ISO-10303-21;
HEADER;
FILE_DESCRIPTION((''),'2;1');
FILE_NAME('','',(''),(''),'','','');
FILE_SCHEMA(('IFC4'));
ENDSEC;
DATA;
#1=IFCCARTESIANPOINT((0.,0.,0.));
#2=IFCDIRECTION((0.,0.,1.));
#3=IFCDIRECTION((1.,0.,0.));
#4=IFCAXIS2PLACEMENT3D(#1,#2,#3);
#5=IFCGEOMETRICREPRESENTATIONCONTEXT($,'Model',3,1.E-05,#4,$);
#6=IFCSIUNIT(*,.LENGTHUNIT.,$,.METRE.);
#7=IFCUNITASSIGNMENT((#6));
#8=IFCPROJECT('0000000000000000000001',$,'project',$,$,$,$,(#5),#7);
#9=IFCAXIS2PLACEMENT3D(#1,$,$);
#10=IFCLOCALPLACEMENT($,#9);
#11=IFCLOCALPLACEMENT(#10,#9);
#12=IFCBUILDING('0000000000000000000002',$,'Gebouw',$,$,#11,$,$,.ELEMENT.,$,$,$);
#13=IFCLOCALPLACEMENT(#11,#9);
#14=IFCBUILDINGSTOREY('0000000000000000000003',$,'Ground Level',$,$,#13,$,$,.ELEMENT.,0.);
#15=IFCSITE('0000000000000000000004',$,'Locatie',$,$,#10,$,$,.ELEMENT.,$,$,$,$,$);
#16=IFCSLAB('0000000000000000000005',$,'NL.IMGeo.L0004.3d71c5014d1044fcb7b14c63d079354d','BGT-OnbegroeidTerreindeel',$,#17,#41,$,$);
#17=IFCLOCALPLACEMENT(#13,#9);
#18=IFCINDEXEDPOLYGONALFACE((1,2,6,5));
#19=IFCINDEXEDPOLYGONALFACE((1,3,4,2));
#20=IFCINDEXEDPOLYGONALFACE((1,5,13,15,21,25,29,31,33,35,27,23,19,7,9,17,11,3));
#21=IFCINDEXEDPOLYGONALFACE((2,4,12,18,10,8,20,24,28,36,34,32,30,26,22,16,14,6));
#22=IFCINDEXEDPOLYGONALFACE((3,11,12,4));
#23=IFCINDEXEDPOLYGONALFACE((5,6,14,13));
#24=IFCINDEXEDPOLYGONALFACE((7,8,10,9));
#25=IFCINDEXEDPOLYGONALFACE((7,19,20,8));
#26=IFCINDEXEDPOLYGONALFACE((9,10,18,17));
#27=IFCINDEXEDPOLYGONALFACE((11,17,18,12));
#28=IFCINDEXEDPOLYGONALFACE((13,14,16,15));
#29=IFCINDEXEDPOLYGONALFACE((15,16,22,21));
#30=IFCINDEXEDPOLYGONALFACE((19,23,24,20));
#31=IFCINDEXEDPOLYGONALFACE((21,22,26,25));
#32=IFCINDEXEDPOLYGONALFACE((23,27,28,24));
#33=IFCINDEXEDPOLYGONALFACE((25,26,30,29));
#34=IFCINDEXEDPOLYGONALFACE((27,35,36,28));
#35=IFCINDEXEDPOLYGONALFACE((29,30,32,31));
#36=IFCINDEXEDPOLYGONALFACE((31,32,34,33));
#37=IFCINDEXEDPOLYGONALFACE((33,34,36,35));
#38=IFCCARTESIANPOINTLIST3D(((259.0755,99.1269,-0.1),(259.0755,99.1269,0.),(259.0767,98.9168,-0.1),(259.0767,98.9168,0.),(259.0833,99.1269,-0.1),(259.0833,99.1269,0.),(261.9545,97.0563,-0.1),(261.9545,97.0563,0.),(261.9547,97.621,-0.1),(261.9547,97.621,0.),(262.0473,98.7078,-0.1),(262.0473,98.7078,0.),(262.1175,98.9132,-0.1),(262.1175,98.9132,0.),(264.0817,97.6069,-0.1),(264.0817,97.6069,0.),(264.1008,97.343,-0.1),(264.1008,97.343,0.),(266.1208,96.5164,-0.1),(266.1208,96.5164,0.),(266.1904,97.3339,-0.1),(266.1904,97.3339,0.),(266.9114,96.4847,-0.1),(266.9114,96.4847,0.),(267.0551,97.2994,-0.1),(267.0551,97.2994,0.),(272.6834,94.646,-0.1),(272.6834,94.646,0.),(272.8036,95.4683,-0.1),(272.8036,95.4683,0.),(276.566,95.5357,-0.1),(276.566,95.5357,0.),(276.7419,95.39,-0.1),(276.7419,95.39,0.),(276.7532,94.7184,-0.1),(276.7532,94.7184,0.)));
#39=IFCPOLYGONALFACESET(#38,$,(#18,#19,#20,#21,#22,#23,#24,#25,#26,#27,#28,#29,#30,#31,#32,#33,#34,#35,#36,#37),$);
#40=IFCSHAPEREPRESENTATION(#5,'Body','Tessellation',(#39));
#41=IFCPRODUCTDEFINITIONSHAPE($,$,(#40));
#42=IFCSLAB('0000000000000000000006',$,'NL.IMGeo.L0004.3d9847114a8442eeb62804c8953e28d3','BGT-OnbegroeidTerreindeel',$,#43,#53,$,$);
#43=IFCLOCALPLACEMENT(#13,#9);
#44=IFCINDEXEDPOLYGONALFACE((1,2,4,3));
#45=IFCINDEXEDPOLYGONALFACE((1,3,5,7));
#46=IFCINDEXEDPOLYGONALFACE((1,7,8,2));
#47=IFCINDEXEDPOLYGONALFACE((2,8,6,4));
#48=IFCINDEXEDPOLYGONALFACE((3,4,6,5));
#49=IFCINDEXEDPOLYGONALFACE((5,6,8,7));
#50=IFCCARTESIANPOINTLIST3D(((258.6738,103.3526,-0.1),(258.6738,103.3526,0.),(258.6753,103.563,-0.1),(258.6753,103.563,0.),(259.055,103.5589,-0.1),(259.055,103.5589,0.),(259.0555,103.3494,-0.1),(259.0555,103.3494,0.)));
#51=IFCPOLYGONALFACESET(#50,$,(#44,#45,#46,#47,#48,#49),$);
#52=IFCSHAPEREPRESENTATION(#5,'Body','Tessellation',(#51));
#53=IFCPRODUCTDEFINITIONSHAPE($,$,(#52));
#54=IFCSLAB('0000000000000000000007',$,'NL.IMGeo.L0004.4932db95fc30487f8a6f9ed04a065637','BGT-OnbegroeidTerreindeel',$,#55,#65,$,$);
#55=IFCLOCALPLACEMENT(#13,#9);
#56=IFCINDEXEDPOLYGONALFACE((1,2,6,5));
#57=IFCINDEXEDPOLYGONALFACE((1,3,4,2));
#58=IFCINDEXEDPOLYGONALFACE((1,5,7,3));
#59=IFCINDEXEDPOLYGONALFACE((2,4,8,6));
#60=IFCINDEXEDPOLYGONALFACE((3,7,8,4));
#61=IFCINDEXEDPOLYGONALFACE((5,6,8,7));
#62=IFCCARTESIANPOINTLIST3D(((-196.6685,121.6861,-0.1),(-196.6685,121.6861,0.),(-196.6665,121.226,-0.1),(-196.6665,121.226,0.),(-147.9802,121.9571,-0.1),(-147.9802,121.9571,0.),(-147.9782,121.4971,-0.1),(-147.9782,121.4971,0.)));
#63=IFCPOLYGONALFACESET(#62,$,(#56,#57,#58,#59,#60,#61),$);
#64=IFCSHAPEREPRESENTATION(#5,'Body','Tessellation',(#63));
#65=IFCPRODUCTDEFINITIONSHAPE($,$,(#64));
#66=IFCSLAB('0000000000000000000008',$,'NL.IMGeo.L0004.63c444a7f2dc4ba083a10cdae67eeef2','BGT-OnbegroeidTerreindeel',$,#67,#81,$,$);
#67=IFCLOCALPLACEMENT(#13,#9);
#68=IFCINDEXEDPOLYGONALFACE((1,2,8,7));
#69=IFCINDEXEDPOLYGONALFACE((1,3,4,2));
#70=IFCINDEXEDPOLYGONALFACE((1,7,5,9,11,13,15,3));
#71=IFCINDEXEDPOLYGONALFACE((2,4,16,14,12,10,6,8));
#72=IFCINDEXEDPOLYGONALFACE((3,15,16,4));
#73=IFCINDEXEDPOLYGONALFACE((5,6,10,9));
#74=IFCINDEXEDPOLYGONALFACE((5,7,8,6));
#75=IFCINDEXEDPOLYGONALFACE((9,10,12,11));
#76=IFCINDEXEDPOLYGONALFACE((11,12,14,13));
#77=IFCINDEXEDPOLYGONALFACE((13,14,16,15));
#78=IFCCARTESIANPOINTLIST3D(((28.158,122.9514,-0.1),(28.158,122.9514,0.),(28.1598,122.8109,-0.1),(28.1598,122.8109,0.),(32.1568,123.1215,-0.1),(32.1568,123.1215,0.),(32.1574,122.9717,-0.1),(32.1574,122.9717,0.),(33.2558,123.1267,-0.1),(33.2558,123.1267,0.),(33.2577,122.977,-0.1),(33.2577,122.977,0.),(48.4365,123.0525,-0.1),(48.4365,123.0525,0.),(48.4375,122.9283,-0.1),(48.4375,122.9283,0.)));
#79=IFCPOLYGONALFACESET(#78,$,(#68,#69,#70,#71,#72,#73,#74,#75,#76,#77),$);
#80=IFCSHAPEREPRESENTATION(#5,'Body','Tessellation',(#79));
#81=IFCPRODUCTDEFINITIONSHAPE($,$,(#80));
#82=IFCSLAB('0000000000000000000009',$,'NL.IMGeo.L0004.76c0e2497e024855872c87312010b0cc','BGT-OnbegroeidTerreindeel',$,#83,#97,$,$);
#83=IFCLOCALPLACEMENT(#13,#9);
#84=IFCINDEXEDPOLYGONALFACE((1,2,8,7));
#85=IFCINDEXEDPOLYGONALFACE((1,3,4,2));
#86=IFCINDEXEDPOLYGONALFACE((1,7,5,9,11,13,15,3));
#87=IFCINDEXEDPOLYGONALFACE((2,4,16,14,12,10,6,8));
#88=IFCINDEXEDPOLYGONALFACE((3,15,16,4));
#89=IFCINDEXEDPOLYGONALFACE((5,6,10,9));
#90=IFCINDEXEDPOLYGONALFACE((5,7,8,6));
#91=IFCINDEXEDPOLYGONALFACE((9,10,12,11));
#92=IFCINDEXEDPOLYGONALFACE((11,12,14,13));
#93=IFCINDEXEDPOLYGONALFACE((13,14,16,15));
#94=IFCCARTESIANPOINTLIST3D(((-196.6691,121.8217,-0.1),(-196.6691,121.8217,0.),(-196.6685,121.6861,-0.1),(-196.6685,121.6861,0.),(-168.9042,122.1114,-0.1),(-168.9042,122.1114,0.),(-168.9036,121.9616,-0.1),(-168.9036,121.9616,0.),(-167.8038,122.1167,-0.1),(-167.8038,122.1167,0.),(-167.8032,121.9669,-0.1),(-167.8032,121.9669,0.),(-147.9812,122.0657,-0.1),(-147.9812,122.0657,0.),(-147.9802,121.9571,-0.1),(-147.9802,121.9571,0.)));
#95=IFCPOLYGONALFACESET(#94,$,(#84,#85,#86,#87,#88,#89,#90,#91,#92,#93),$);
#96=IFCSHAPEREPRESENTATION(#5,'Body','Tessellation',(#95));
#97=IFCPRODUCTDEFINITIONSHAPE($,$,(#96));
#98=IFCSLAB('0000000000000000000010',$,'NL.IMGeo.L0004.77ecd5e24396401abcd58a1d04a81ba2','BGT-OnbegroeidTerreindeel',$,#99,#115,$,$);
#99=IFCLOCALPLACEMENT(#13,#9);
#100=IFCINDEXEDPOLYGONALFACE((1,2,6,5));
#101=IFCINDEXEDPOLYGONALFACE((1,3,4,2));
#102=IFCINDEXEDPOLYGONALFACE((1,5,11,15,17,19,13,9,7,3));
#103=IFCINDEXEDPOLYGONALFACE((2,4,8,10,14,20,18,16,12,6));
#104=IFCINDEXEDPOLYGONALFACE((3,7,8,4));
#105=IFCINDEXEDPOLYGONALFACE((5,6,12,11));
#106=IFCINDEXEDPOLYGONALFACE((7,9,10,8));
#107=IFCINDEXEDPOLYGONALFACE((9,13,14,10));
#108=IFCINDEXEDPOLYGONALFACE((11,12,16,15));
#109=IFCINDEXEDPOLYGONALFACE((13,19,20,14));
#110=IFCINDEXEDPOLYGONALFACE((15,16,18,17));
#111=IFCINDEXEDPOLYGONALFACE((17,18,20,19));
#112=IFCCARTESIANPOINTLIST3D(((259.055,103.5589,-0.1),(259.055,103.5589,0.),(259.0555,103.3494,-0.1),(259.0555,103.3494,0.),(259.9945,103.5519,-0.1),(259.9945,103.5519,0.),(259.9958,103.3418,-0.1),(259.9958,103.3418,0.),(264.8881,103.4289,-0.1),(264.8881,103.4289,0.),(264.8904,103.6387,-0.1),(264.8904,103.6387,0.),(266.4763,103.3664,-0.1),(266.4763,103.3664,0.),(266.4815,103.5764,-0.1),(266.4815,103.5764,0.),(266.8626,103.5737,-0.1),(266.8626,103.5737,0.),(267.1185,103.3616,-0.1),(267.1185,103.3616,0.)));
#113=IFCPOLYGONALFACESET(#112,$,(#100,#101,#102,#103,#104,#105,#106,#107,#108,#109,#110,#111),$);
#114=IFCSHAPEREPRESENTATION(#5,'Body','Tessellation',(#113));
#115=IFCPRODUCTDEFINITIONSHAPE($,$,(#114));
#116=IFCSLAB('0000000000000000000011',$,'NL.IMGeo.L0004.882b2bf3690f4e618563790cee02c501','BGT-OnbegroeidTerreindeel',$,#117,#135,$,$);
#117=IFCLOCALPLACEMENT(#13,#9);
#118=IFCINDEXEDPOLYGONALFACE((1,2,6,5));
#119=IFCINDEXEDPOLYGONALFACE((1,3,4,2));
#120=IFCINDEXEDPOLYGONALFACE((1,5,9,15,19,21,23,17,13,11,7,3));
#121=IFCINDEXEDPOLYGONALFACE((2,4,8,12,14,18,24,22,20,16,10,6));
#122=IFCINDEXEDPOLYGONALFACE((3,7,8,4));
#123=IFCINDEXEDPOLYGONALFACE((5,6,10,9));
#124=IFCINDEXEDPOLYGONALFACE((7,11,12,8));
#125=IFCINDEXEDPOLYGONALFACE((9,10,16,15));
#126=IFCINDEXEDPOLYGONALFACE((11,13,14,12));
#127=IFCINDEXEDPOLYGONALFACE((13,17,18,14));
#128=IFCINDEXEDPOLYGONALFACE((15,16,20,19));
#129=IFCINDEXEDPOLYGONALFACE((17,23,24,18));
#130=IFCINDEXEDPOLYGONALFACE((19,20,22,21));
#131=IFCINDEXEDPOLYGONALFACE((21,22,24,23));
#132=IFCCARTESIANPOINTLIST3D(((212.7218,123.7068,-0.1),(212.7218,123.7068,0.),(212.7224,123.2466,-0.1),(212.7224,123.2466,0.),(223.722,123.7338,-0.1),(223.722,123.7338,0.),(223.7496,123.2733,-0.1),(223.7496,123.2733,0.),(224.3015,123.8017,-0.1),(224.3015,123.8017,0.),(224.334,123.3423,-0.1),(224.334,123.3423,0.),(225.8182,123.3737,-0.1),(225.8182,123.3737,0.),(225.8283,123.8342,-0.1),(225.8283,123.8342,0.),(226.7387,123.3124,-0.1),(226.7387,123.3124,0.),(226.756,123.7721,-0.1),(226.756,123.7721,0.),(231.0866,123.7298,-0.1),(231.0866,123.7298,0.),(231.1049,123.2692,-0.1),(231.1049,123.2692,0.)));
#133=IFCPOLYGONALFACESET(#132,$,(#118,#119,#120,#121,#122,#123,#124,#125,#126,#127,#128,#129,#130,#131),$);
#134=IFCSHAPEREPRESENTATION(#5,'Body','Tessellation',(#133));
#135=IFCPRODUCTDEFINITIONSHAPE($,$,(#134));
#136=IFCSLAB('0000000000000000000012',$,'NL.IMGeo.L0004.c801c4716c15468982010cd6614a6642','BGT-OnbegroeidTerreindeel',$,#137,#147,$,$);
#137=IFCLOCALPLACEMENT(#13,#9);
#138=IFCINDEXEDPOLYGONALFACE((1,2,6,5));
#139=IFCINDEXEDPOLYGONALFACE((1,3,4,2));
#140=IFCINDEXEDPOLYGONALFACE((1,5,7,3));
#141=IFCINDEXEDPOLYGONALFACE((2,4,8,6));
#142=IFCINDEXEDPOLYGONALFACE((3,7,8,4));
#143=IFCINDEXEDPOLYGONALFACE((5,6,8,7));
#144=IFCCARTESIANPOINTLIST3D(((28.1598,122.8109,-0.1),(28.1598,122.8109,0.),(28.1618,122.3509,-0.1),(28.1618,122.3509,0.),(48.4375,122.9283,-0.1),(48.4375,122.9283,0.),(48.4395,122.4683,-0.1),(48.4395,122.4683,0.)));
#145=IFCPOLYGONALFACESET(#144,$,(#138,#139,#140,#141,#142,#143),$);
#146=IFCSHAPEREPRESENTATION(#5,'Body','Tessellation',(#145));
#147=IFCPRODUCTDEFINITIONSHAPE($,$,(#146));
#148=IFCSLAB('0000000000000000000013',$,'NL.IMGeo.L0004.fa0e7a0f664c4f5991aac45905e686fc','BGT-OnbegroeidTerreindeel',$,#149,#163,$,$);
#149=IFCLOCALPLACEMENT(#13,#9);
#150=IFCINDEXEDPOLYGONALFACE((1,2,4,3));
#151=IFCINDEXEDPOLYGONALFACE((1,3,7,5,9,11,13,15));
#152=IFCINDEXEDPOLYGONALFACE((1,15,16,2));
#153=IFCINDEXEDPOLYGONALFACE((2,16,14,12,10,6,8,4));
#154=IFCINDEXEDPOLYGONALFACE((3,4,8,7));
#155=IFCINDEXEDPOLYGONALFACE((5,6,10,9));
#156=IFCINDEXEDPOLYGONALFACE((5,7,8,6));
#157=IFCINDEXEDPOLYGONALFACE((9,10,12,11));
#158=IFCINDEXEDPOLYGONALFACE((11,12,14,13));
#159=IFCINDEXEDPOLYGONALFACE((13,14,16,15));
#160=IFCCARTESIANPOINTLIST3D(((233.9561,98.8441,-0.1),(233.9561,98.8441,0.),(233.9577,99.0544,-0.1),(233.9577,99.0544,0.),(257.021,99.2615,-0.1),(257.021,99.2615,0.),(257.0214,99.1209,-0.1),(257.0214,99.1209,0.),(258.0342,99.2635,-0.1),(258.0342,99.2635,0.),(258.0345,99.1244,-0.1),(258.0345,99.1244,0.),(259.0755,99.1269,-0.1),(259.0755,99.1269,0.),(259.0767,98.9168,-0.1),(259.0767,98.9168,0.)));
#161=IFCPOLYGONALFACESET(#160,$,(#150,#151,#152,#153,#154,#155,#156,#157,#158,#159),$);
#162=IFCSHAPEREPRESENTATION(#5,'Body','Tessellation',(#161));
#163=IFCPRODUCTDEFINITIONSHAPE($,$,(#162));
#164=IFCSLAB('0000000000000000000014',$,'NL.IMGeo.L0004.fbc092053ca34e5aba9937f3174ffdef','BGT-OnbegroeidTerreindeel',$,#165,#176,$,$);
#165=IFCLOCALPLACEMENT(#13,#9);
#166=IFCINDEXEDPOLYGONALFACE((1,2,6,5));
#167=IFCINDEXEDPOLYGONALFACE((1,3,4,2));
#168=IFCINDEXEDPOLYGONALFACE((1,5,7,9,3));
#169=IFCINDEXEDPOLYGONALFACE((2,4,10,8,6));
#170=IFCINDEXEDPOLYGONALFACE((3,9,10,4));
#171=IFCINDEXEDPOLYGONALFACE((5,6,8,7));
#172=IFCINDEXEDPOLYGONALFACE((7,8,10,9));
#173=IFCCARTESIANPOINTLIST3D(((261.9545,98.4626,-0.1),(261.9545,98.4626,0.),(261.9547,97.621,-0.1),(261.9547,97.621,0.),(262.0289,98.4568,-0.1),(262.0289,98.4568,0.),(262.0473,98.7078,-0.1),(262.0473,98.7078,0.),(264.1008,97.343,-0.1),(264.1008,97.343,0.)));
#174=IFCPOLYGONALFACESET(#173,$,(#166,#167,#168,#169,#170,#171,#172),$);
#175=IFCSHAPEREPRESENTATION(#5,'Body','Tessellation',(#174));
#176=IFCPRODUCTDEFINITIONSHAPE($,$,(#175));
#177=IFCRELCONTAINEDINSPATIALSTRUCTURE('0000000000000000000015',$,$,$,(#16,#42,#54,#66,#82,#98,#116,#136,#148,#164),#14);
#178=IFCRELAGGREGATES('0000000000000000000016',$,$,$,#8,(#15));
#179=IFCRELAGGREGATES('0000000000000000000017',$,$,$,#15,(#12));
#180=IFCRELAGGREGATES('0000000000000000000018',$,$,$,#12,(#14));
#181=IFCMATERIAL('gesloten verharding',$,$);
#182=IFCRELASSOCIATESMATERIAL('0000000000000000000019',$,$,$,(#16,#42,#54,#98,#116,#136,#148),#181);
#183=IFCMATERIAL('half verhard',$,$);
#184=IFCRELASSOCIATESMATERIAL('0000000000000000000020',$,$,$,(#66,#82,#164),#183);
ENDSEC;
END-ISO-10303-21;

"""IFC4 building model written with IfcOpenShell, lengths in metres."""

from ifc_helpers import new_model, si_unit, frame, origin, origin_with_axes, place, context, project, spatial, polyline, outline, extrude, material, element, save


model = new_model("IFC4")

# Units and contexts
model_context = context("Model", 3, precision=1e-05, world=origin_with_axes())
ifc_project = project(units=[si_unit("LENGTHUNIT", "METRE")], contexts=[model_context])

# Site, building, storey
site_placement = place(None, origin())
site = spatial("IfcSite", under=ifc_project, at=site_placement, Name="Locatie", CompositionType="ELEMENT")
building_placement = place(site_placement, origin())
building = spatial("IfcBuilding", under=site, at=building_placement, Name="Gebouw", CompositionType="ELEMENT")
storey_placement = place(building_placement, origin())
storey = spatial("IfcBuildingStorey", under=building, at=storey_placement, Name="Ground Level", CompositionType="ELEMENT", Elevation=0.0)

# Slabs
ifc_material_1 = material(Name="gesloten verharding")
ifc_material_2 = material(Name="half verhard")
slab_1_placement = place(storey_placement, origin())
element("IfcSlab", 1, at=slab_1_placement, inside=storey, material=ifc_material_1, Name="NL.IMGeo.L0004.3d71c5014d1044fcb7b14c63d079354d", Description="BGT-OnbegroeidTerreindeel", context=model_context, shape_type="SweptSolid", body=[
    extrude(outline(polyline([(276.7532, 94.7184), (272.6834, 94.646), (266.9114, 96.4847), (266.1208, 96.5164), (261.9545, 97.0563), (261.9547, 97.621), (264.1008, 97.343), (262.0473, 98.7078), (259.0767, 98.9168), (259.0755, 99.1269), (259.0833, 99.1269), (262.1175, 98.9132), (264.0817, 97.6069), (266.1904, 97.3339), (267.0551, 97.2994), (272.8036, 95.4683), (276.566, 95.5357), (276.7419, 95.39), (276.7532, 94.7184)])), frame((0.0, 0.0, -0.1), z_axis=(0.0, 0.0, 1.0), x_axis=(1.0, 0.0, 0.0)), (0.0, 0.0, 1.0), 0.1),
])
slab_2_placement = place(storey_placement, origin())
element("IfcSlab", 2, at=slab_2_placement, inside=storey, material=ifc_material_1, Name="NL.IMGeo.L0004.3d9847114a8442eeb62804c8953e28d3", Description="BGT-OnbegroeidTerreindeel", context=model_context, shape_type="SweptSolid", body=[
    extrude(outline(polyline([(258.6738, 103.3526), (258.6753, 103.563), (259.055, 103.5589), (259.0555, 103.3494), (258.6738, 103.3526)])), frame((0.0, 0.0, -0.1), z_axis=(0.0, 0.0, 1.0), x_axis=(1.0, 0.0, 0.0)), (0.0, 0.0, 1.0), 0.1),
])
slab_3_placement = place(storey_placement, origin())
element("IfcSlab", 3, at=slab_3_placement, inside=storey, material=ifc_material_1, Name="NL.IMGeo.L0004.4932db95fc30487f8a6f9ed04a065637", Description="BGT-OnbegroeidTerreindeel", context=model_context, shape_type="SweptSolid", body=[
    extrude(outline(polyline([(-196.6685, 121.6861), (-147.9802, 121.9571), (-147.9782, 121.4971), (-196.6665, 121.226), (-196.6685, 121.6861)])), frame((0.0, 0.0, -0.1), z_axis=(0.0, 0.0, 1.0), x_axis=(1.0, 0.0, 0.0)), (0.0, 0.0, 1.0), 0.1),
])
slab_4_placement = place(storey_placement, origin())
element("IfcSlab", 4, at=slab_4_placement, inside=storey, material=ifc_material_2, Name="NL.IMGeo.L0004.63c444a7f2dc4ba083a10cdae67eeef2", Description="BGT-OnbegroeidTerreindeel", context=model_context, shape_type="SweptSolid", body=[
    extrude(outline(polyline([(28.158, 122.9514), (32.1574, 122.9717), (32.1568, 123.1215), (33.2558, 123.1267), (33.2577, 122.977), (48.4365, 123.0525), (48.4375, 122.9283), (28.1598, 122.8109), (28.158, 122.9514)])), frame((0.0, 0.0, -0.1), z_axis=(0.0, 0.0, 1.0), x_axis=(1.0, 0.0, 0.0)), (0.0, 0.0, 1.0), 0.1),
])
slab_5_placement = place(storey_placement, origin())
element("IfcSlab", 5, at=slab_5_placement, inside=storey, material=ifc_material_2, Name="NL.IMGeo.L0004.76c0e2497e024855872c87312010b0cc", Description="BGT-OnbegroeidTerreindeel", context=model_context, shape_type="SweptSolid", body=[
    extrude(outline(polyline([(-196.6691, 121.8217), (-168.9036, 121.9616), (-168.9042, 122.1114), (-167.8038, 122.1167), (-167.8032, 121.9669), (-147.9812, 122.0657), (-147.9802, 121.9571), (-196.6685, 121.6861), (-196.6691, 121.8217)])), frame((0.0, 0.0, -0.1), z_axis=(0.0, 0.0, 1.0), x_axis=(1.0, 0.0, 0.0)), (0.0, 0.0, 1.0), 0.1),
])
slab_6_placement = place(storey_placement, origin())
element("IfcSlab", 6, at=slab_6_placement, inside=storey, material=ifc_material_1, Name="NL.IMGeo.L0004.77ecd5e24396401abcd58a1d04a81ba2", Description="BGT-OnbegroeidTerreindeel", context=model_context, shape_type="SweptSolid", body=[
    extrude(outline(polyline([(266.4763, 103.3664), (264.8881, 103.4289), (259.9958, 103.3418), (259.0555, 103.3494), (259.055, 103.5589), (259.9945, 103.5519), (264.8904, 103.6387), (266.4815, 103.5764), (266.8626, 103.5737), (267.1185, 103.3616), (266.4763, 103.3664)])), frame((0.0, 0.0, -0.1), z_axis=(0.0, 0.0, 1.0), x_axis=(1.0, 0.0, 0.0)), (0.0, 0.0, 1.0), 0.1),
])
slab_7_placement = place(storey_placement, origin())
element("IfcSlab", 7, at=slab_7_placement, inside=storey, material=ifc_material_1, Name="NL.IMGeo.L0004.882b2bf3690f4e618563790cee02c501", Description="BGT-OnbegroeidTerreindeel", context=model_context, shape_type="SweptSolid", body=[
    extrude(outline(polyline([(212.7218, 123.7068), (223.722, 123.7338), (224.3015, 123.8017), (225.8283, 123.8342), (226.756, 123.7721), (231.0866, 123.7298), (231.1049, 123.2692), (226.7387, 123.3124), (225.8182, 123.3737), (224.334, 123.3423), (223.7496, 123.2733), (212.7224, 123.2466), (212.7218, 123.7068)])), frame((0.0, 0.0, -0.1), z_axis=(0.0, 0.0, 1.0), x_axis=(1.0, 0.0, 0.0)), (0.0, 0.0, 1.0), 0.1),
])
slab_8_placement = place(storey_placement, origin())
element("IfcSlab", 8, at=slab_8_placement, inside=storey, material=ifc_material_1, Name="NL.IMGeo.L0004.c801c4716c15468982010cd6614a6642", Description="BGT-OnbegroeidTerreindeel", context=model_context, shape_type="SweptSolid", body=[
    extrude(outline(polyline([(28.1598, 122.8109), (48.4375, 122.9283), (48.4395, 122.4683), (28.1618, 122.3509), (28.1598, 122.8109)])), frame((0.0, 0.0, -0.1), z_axis=(0.0, 0.0, 1.0), x_axis=(1.0, 0.0, 0.0)), (0.0, 0.0, 1.0), 0.1),
])
slab_9_placement = place(storey_placement, origin())
element("IfcSlab", 9, at=slab_9_placement, inside=storey, material=ifc_material_1, Name="NL.IMGeo.L0004.fa0e7a0f664c4f5991aac45905e686fc", Description="BGT-OnbegroeidTerreindeel", context=model_context, shape_type="SweptSolid", body=[
    extrude(outline(polyline([(257.0214, 99.1209), (257.021, 99.2615), (258.0342, 99.2635), (258.0345, 99.1244), (259.0755, 99.1269), (259.0767, 98.9168), (233.9561, 98.8441), (233.9577, 99.0544), (257.0214, 99.1209)])), frame((0.0, 0.0, -0.1), z_axis=(0.0, 0.0, 1.0), x_axis=(1.0, 0.0, 0.0)), (0.0, 0.0, 1.0), 0.1),
])
slab_10_placement = place(storey_placement, origin())
element("IfcSlab", 10, at=slab_10_placement, inside=storey, material=ifc_material_2, Name="NL.IMGeo.L0004.fbc092053ca34e5aba9937f3174ffdef", Description="BGT-OnbegroeidTerreindeel", context=model_context, shape_type="SweptSolid", body=[
    extrude(outline(polyline([(261.9545, 98.4626), (262.0289, 98.4568), (262.0473, 98.7078), (264.1008, 97.343), (261.9547, 97.621), (261.9545, 98.4626)])), frame((0.0, 0.0, -0.1), z_axis=(0.0, 0.0, 1.0), x_axis=(1.0, 0.0, 0.0)), (0.0, 0.0, 1.0), 0.1),
])

save(model, "model.ifc")
